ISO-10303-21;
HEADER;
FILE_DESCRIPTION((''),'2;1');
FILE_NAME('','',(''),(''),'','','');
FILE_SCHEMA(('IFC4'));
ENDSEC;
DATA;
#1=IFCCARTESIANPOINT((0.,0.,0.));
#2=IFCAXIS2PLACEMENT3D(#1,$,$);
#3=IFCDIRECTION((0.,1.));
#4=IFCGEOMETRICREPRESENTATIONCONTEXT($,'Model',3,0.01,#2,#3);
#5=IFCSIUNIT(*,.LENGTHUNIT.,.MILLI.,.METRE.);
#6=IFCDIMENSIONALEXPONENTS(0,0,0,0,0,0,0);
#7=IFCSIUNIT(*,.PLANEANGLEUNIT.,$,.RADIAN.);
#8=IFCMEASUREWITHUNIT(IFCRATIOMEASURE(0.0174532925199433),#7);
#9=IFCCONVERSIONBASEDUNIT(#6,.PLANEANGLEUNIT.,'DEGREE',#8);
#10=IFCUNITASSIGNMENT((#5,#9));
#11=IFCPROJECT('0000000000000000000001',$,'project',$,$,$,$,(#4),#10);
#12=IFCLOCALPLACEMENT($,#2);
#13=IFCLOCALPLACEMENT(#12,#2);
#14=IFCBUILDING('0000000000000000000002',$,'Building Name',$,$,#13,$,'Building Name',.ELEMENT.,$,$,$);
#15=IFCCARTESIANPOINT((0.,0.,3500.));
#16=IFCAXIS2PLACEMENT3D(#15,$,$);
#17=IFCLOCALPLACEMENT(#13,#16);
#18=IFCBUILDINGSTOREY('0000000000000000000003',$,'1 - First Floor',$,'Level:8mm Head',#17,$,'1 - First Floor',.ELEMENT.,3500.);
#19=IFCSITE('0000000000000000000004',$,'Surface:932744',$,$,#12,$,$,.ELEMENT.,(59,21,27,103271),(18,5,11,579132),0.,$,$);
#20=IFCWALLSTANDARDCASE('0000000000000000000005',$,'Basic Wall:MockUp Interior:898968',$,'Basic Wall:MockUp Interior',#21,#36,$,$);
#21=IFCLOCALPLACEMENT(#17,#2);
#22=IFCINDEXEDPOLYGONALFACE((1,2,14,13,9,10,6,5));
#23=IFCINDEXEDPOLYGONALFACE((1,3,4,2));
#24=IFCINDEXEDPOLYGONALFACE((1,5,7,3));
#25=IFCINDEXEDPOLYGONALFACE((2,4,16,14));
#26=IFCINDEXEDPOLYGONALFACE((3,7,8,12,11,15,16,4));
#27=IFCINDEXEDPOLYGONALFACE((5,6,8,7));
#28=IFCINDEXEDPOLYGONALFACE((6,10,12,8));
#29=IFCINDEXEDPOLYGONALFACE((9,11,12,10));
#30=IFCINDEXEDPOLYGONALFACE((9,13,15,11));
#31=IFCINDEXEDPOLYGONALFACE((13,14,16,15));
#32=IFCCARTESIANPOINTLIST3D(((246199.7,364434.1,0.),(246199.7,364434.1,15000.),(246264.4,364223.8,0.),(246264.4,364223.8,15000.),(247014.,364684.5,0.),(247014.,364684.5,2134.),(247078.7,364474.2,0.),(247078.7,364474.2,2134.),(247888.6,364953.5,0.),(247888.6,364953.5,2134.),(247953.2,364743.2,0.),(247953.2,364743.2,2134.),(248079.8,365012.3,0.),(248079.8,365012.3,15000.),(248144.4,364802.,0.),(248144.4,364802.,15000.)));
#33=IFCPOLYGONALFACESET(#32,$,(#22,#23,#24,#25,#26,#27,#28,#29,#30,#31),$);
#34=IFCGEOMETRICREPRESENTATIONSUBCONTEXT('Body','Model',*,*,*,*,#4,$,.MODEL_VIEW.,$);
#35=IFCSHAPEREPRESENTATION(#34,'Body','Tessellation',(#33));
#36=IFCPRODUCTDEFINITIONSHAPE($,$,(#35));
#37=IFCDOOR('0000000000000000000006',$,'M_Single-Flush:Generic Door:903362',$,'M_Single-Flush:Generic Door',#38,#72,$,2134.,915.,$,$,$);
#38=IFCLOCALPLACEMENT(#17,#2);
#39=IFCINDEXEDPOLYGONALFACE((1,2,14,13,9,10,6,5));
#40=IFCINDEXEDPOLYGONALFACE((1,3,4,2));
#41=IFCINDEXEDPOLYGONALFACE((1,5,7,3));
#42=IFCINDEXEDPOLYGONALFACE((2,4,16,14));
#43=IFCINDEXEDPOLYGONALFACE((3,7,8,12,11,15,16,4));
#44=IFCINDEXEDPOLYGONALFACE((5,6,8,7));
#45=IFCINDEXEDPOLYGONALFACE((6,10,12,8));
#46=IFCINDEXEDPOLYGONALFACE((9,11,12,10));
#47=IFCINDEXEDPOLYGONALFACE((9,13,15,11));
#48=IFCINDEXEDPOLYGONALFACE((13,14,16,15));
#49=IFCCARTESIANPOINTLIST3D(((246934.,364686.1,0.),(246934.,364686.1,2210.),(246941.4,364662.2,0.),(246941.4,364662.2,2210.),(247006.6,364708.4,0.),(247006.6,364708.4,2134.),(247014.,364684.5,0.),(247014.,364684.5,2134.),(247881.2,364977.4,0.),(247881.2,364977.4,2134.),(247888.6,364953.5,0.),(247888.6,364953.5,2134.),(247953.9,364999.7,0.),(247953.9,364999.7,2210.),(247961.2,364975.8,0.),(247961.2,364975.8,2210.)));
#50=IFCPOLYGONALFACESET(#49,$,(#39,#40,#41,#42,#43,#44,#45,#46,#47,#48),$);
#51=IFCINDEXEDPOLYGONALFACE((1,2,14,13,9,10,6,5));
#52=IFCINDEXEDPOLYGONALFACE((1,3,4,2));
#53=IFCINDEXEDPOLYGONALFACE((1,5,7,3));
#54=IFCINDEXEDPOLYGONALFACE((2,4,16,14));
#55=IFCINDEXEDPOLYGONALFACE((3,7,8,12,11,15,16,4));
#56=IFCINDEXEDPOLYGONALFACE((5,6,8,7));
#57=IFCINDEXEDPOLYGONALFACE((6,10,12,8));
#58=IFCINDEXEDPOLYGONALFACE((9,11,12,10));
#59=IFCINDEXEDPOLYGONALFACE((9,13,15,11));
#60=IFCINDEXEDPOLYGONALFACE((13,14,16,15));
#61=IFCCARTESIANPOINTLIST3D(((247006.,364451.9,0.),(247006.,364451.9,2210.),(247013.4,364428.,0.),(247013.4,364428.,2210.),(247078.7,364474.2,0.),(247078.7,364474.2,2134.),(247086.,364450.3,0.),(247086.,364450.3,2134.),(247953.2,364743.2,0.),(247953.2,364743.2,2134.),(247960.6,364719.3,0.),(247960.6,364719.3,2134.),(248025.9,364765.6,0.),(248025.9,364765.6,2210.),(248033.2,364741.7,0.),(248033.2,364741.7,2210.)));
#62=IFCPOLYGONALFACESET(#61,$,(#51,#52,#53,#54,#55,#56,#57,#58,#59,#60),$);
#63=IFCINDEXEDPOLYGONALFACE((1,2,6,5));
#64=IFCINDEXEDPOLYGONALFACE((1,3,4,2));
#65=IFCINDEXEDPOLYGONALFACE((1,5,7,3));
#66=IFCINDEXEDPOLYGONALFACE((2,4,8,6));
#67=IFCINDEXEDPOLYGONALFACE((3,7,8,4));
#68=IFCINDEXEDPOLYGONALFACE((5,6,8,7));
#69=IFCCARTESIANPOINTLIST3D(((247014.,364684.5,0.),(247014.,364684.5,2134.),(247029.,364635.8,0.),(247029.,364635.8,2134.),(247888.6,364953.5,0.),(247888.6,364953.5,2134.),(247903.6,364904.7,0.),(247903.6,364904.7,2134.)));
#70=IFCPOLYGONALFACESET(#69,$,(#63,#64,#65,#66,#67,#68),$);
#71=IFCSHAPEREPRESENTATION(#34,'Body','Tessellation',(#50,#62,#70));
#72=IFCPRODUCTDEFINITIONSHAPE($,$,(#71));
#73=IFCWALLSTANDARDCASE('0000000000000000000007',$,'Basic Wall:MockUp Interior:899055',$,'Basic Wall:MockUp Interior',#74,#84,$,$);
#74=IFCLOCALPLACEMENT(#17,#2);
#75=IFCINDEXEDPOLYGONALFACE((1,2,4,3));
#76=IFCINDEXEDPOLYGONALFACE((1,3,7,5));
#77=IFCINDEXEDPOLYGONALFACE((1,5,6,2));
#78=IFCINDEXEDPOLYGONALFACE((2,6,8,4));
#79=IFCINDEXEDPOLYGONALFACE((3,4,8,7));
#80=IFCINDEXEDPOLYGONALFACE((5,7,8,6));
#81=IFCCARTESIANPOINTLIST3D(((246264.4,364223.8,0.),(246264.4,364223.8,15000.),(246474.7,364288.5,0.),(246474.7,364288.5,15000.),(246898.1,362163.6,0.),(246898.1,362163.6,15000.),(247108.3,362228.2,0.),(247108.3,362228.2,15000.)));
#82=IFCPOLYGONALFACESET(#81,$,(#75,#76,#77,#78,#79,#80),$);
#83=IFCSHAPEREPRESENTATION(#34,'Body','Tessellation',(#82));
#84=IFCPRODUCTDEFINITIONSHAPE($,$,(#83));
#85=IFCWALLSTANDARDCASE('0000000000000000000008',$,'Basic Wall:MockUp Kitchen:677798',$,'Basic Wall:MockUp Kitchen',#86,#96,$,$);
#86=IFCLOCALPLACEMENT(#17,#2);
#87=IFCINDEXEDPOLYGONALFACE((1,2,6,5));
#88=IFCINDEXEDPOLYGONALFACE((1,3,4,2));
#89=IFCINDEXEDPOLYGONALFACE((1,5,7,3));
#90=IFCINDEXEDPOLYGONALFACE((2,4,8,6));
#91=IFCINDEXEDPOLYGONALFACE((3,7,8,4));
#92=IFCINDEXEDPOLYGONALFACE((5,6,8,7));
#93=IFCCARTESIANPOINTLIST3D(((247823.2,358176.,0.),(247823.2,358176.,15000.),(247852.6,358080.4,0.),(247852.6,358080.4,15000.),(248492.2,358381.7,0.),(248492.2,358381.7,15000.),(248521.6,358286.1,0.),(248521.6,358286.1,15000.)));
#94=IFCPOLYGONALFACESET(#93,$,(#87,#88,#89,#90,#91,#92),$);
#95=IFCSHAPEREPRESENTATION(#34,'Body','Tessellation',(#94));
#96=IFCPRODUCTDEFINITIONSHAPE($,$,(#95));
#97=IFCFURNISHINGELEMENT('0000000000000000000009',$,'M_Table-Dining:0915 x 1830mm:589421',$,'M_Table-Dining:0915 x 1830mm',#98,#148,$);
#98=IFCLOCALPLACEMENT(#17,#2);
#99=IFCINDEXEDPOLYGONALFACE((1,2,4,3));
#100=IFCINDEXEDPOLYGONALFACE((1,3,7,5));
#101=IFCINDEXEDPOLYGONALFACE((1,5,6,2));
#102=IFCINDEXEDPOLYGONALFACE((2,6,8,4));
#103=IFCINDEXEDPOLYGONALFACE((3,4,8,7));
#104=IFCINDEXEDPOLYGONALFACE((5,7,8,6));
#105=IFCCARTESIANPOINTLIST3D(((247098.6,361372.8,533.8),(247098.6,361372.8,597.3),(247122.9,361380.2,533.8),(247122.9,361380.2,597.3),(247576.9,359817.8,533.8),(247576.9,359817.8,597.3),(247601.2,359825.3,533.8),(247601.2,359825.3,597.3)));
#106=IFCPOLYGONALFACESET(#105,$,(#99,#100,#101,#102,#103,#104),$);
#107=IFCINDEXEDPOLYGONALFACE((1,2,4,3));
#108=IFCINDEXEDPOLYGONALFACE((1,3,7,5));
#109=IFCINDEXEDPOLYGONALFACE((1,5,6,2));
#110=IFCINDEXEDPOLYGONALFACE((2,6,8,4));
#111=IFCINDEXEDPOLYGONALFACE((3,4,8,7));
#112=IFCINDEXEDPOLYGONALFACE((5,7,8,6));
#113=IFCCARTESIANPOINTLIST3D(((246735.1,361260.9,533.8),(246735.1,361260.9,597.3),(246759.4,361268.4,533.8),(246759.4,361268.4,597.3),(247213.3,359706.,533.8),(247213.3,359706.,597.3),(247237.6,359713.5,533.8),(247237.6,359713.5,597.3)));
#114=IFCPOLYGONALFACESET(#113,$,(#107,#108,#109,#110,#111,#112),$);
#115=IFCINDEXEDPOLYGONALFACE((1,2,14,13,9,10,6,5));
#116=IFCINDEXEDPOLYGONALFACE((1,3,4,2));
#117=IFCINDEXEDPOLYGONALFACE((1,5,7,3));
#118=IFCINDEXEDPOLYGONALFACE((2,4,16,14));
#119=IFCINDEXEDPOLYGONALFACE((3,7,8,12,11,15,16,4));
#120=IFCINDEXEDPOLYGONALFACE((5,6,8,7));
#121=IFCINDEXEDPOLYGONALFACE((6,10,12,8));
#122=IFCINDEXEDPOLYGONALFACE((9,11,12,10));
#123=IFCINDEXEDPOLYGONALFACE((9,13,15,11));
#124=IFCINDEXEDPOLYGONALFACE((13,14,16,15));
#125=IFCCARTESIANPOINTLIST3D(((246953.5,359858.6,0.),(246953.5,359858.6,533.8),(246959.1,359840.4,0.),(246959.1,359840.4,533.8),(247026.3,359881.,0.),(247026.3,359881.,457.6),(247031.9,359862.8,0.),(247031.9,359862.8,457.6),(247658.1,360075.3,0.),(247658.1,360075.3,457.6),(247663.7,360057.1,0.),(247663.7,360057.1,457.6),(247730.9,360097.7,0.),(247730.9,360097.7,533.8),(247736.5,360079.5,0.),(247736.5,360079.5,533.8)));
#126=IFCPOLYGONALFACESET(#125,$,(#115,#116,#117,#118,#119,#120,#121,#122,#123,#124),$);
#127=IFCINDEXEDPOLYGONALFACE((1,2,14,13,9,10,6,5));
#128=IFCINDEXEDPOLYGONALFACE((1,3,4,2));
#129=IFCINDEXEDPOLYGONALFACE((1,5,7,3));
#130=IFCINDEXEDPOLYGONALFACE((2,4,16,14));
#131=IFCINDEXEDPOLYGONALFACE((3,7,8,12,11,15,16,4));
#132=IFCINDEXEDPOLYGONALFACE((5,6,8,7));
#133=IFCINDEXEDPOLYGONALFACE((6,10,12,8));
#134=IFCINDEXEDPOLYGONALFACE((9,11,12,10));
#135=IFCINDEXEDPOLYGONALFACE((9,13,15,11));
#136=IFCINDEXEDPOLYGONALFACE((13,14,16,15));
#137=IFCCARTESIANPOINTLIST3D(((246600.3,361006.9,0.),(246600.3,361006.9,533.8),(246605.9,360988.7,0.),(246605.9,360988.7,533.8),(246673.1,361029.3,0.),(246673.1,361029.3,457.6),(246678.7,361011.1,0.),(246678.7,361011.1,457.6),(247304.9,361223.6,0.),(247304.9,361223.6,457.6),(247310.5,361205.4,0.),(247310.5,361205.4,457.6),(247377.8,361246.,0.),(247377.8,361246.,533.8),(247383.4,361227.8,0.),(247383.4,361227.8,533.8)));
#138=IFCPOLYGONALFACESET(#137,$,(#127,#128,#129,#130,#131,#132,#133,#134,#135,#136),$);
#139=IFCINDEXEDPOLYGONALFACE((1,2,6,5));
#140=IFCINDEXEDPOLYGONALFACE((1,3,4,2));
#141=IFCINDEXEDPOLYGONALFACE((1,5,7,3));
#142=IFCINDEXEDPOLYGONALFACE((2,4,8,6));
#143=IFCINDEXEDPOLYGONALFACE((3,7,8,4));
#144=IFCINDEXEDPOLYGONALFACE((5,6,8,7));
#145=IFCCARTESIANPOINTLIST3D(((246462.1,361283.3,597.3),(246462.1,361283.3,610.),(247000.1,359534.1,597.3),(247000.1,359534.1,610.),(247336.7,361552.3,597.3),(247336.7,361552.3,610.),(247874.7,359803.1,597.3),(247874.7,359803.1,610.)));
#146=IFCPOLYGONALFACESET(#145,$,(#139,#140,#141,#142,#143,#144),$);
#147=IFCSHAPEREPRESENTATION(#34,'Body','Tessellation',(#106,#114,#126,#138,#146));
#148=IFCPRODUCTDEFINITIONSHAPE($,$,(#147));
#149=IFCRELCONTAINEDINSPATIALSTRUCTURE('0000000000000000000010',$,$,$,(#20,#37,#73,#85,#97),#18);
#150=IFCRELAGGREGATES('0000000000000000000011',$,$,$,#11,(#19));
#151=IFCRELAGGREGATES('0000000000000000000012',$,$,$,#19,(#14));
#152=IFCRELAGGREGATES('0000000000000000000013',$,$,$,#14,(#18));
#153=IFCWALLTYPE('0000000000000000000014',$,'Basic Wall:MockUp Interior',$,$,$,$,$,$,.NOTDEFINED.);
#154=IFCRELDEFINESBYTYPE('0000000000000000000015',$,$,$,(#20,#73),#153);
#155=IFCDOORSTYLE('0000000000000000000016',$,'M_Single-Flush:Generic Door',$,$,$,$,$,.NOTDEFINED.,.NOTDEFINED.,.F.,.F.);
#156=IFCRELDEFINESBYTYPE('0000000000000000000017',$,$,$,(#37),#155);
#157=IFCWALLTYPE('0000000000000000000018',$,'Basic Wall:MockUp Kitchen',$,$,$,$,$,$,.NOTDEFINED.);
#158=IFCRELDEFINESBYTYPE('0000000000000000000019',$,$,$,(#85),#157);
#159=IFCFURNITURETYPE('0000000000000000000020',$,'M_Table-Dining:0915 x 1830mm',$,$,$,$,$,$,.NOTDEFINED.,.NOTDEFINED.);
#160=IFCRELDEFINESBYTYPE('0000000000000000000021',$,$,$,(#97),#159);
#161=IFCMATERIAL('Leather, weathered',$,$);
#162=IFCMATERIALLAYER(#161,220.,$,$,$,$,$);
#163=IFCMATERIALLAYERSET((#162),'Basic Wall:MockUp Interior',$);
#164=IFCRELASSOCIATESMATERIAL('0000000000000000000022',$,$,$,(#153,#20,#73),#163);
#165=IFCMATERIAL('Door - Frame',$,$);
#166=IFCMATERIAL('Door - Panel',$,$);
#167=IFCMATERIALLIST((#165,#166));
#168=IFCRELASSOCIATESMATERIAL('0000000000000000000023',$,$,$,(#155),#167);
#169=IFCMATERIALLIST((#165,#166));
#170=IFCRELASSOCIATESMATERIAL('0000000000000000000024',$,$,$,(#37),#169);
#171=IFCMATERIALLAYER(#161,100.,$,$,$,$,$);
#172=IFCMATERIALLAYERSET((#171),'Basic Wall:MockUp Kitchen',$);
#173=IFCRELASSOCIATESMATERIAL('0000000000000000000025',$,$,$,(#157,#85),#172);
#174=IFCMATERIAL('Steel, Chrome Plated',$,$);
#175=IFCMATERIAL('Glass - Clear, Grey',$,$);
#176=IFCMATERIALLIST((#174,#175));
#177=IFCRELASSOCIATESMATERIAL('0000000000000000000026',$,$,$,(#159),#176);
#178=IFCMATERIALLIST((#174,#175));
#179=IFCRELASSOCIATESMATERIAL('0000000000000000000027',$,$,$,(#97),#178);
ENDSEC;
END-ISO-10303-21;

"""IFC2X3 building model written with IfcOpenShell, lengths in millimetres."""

from ifc_helpers import new_model, entity, si_unit, converted_unit, direction, frame, frame_2d, origin, origin_2d_with_axis, place, context, subcontext, project, spatial, polyline, rectangle, outline, extrude, source, transform, mapped, material, material_list, layer, layer_set, layer_usage, type_object, type_shapes, element, fill, save


model = new_model("IFC2X3")

# Units and contexts
model_context = context("Model", 3, precision=0.01, world=origin(), true_north=direction((0.0, 1.0)))
body_context = subcontext(model_context, "Body", "Model", "MODEL_VIEW")
ifc_project = project(units=[si_unit("LENGTHUNIT", "METRE", prefix="MILLI"), converted_unit("PLANEANGLEUNIT", "DEGREE", entity("IfcRatioMeasure", 0.0174532925199433), si_unit("PLANEANGLEUNIT", "RADIAN"), dimensions=[0, 0, 0, 0, 0, 0, 0])], contexts=[model_context])

# Site, building, storey
site_placement = place(None, origin())
site = spatial("IfcSite", under=ifc_project, at=site_placement, Name="Surface:932744", CompositionType="ELEMENT", RefLatitude=(59, 21, 27, 103271), RefLongitude=(18, 5, 11, 579132), RefElevation=0.0)
building_placement = place(site_placement, origin())
building = spatial("IfcBuilding", under=site, at=building_placement, Name="Building Name", LongName="Building Name", CompositionType="ELEMENT")
storey_placement = place(building_placement, frame((0.0, 0.0, 3500.0)))
storey = spatial("IfcBuildingStorey", under=building, at=storey_placement, Name="1 - First Floor", ObjectType="Level:8mm Head", LongName="1 - First Floor", CompositionType="ELEMENT", Elevation=3500.0)

# Shared definitions
ifc_material_1 = material(Name="Leather, weathered")
ifc_material_2 = material(Name="Door - Frame")
ifc_material_3 = material(Name="Door - Panel")

# Shared definitions
ifc_layer_1 = layer(ifc_material_1, 220.0)
ifc_layer_set_1 = layer_set([ifc_layer_1], Name="Basic Wall:MockUp Interior")
wall_type_1 = type_object("IfcWallType", Name="Basic Wall:MockUp Interior", PredefinedType="NOTDEFINED", material=ifc_layer_set_1)

# Shared definitions
ifc_material_list_1 = material_list([ifc_material_2, ifc_material_3])
door_style_1 = type_object("IfcDoorStyle", Name="M_Single-Flush:Generic Door", ConstructionType="NOTDEFINED", OperationType="NOTDEFINED", ParameterTakesPrecedence=False, Sizeable=False, material=ifc_material_list_1)
shared_shape_1 = source(origin(), body_context, "Body", "SweptSolid", [
    extrude(outline(polyline([(-533.5, -1124.0), (533.5, -1124.0), (533.5, 1086.0), (457.5, 1086.0), (457.5, -1048.0), (-457.5, -1048.0), (-457.5, 1086.0), (-533.5, 1086.0), (-533.5, -1124.0)])), frame((457.5, 220.0, 1086.0), z_axis=(0.0, 1.0, 0.0), x_axis=(1.0, 0.0, 0.0)), (0.0, 0.0, 1.0), 25.0),
    extrude(outline(polyline([(-1124.0, -533.5), (1086.0, -533.5), (1086.0, -457.5), (-1048.0, -457.5), (-1048.0, 457.5), (1086.0, 457.5), (1086.0, 533.5), (-1124.0, 533.5), (-1124.0, -533.5)])), frame((457.5, -25.0, 1086.0), z_axis=(0.0, 1.0, 0.0), x_axis=(0.0, 0.0, -1.0)), (0.0, 0.0, 1.0), 25.0),
    extrude(rectangle(XDim=51.0, YDim=915.0, at=frame_2d((0.0, 0.0), x_axis=(1.0, 0.0))), frame((457.5, 194.5, 0.0), z_axis=(0.0, 0.0, 1.0), x_axis=(0.0, 1.0, 0.0)), (0.0, 0.0, 1.0), 2134.0),
])
type_shapes(door_style_1, [shared_shape_1])

# Wall, opening, door
ifc_layer_usage_1 = layer_usage(ifc_layer_set_1, "AXIS2", "NEGATIVE", 110.0)
wall_1_placement = place(storey_placement, frame((248112.1, 364907.2, 0.0), z_axis=(0.0, 0.0, 1.0), x_axis=(-0.955818, -0.293958, 0.0)))
wall_1 = element("IfcWallStandardCase", 1, at=wall_1_placement, inside=storey, type_object=wall_type_1, material=ifc_layer_usage_1, Name="Basic Wall:MockUp Interior:898968", ObjectType="Basic Wall:MockUp Interior", context=body_context, shape_type="SweptSolid", body=[
    extrude(rectangle(XDim=1967.0, YDim=220.0, at=frame_2d((983.5, 0.0), x_axis=(-1.0, 0.0))), origin(), (0.0, 0.0, 1.0), 15000.0),
])
opening_1_placement = place(wall_1_placement, frame((1115.0, 110.0, 0.0)))
opening_1 = element("IfcOpeningElement", 2, at=opening_1_placement, cuts=wall_1, ObjectType="Opening", context=body_context, shape_type="SweptSolid", body=[
    extrude(rectangle(XDim=915.0, YDim=2134.0, at=frame_2d((1067.0, 457.5), x_axis=(0.0, 1.0))), frame((0.0, 0.0, 0.0), z_axis=(0.0, -1.0, 0.0), x_axis=(0.0, 0.0, 1.0)), (0.0, 0.0, 1.0), 220.0),
])
ifc_material_list_2 = material_list([ifc_material_2, ifc_material_3])
door_1_placement = place(opening_1_placement, frame((0.0, 0.0, 0.0), z_axis=(0.0, 0.0, 1.0), x_axis=(-1.0, 0.0, 0.0)))
door_1 = element("IfcDoor", 3, at=door_1_placement, inside=storey, type_object=door_style_1, material=ifc_material_list_2, Name="M_Single-Flush:Generic Door:903362", ObjectType="M_Single-Flush:Generic Door", OverallHeight=2134.0, OverallWidth=915.0, context=body_context, shape_type="MappedRepresentation", body=[
    mapped(shared_shape_1, transform((0.0, 0.0, 0.0), scale=1.0)),
])
fill(opening_1, door_1)

# Walls
ifc_layer_usage_2 = layer_usage(ifc_layer_set_1, "AXIS2", "NEGATIVE", 110.0)
wall_2_placement = place(storey_placement, frame((246369.5, 364256.2, 0.0), z_axis=(0.0, 0.0, 1.0), x_axis=(0.29398, -0.955811, 0.0)))
element("IfcWallStandardCase", 4, at=wall_2_placement, inside=storey, type_object=wall_type_1, material=ifc_layer_usage_2, Name="Basic Wall:MockUp Interior:899055", ObjectType="Basic Wall:MockUp Interior", context=body_context, shape_type="SweptSolid", body=[
    extrude(rectangle(XDim=2155.5, YDim=220.0, at=frame_2d((1077.8, 0.0), x_axis=(-1.0, 0.0))), origin(), (0.0, 0.0, 1.0), 15000.0),
])
ifc_layer_2 = layer(ifc_material_1, 100.0)
ifc_layer_set_2 = layer_set([ifc_layer_2], Name="Basic Wall:MockUp Kitchen")
ifc_layer_usage_3 = layer_usage(ifc_layer_set_2, "AXIS2", "NEGATIVE", 50.0)
wall_type_2 = type_object("IfcWallType", Name="Basic Wall:MockUp Kitchen", PredefinedType="NOTDEFINED", material=ifc_layer_set_2)
wall_3_placement = place(storey_placement, frame((247837.9, 358128.2, 0.0), z_axis=(0.0, 0.0, 1.0), x_axis=(0.955818, 0.293958, 0.0)))
element("IfcWallStandardCase", 5, at=wall_3_placement, inside=storey, type_object=wall_type_2, material=ifc_layer_usage_3, Name="Basic Wall:MockUp Kitchen:677798", ObjectType="Basic Wall:MockUp Kitchen", context=body_context, shape_type="SweptSolid", body=[
    extrude(rectangle(XDim=699.9, YDim=100.0, at=frame_2d((350.0, 0.0), x_axis=(-1.0, 0.0))), origin(), (0.0, 0.0, 1.0), 15000.0),
])

# Furnishing element
ifc_material_4 = material(Name="Steel, Chrome Plated")
ifc_material_5 = material(Name="Glass - Clear, Grey")
ifc_material_list_3 = material_list([ifc_material_4, ifc_material_5])
ifc_material_list_4 = material_list([ifc_material_4, ifc_material_5])
furniture_type_1 = type_object("IfcFurnitureType", Name="M_Table-Dining:0915 x 1830mm", material=ifc_material_list_4)
shared_shape_2 = source(origin(), body_context, "Body", "SweptSolid", [
    extrude(rectangle(XDim=1626.8, YDim=25.4, at=frame_2d((0.0, 0.0), x_axis=(1.0, 0.0))), frame((18.3, 285.1, 533.8), z_axis=(0.0, 0.0, 1.0), x_axis=(-1.0, 0.0, 0.0)), (0.0, 0.0, 1.0), 63.5),
    extrude(rectangle(XDim=1626.8, YDim=25.4, at=origin_2d_with_axis()), frame((18.3, -95.3, 533.8), z_axis=(0.0, 0.0, 1.0), x_axis=(-1.0, 0.0, 0.0)), (0.0, 0.0, 1.0), 63.5),
    extrude(outline(polyline([(-247.8, -406.7), (285.9, -406.7), (285.9, 406.7), (-247.8, 406.7), (-247.8, 330.5), (209.7, 330.5), (209.7, -330.5), (-247.8, -330.5), (-247.8, -406.7)])), frame((609.4, 95.2, 247.8), z_axis=(1.0, 0.0, 0.0), x_axis=(0.0, 0.0, 1.0)), (0.0, 0.0, 1.0), 19.1),
    extrude(outline(polyline([(-406.7, -285.9), (406.7, -285.9), (406.7, 247.8), (330.5, 247.8), (330.5, -209.7), (-330.5, -209.7), (-330.5, 247.8), (-406.7, 247.8), (-406.7, -285.9)])), frame((-591.9, 95.2, 247.8), z_axis=(1.0, 0.0, 0.0), x_axis=(0.0, -1.0, 0.0)), (0.0, 0.0, 1.0), 19.1),
    extrude(rectangle(XDim=1830.0, YDim=915.0, at=origin_2d_with_axis()), frame((18.3, 95.2, 597.3), z_axis=(0.0, 0.0, 1.0), x_axis=(-1.0, 0.0, 0.0)), (0.0, 0.0, 1.0), 12.7),
])
type_shapes(furniture_type_1, [shared_shape_2])
furnishing_1_placement = place(storey_placement, frame((247072.0, 360532.7, 0.0), z_axis=(0.0, 0.0, 1.0), x_axis=(0.29398, -0.955811, 0.0)))
element("IfcFurnishingElement", 6, at=furnishing_1_placement, inside=storey, type_object=furniture_type_1, material=ifc_material_list_3, Name="M_Table-Dining:0915 x 1830mm:589421", ObjectType="M_Table-Dining:0915 x 1830mm", context=body_context, shape_type="MappedRepresentation", body=[
    mapped(shared_shape_2, transform((0.0, 0.0, 0.0), scale=1.0)),
])

save(model, "model.ifc")
